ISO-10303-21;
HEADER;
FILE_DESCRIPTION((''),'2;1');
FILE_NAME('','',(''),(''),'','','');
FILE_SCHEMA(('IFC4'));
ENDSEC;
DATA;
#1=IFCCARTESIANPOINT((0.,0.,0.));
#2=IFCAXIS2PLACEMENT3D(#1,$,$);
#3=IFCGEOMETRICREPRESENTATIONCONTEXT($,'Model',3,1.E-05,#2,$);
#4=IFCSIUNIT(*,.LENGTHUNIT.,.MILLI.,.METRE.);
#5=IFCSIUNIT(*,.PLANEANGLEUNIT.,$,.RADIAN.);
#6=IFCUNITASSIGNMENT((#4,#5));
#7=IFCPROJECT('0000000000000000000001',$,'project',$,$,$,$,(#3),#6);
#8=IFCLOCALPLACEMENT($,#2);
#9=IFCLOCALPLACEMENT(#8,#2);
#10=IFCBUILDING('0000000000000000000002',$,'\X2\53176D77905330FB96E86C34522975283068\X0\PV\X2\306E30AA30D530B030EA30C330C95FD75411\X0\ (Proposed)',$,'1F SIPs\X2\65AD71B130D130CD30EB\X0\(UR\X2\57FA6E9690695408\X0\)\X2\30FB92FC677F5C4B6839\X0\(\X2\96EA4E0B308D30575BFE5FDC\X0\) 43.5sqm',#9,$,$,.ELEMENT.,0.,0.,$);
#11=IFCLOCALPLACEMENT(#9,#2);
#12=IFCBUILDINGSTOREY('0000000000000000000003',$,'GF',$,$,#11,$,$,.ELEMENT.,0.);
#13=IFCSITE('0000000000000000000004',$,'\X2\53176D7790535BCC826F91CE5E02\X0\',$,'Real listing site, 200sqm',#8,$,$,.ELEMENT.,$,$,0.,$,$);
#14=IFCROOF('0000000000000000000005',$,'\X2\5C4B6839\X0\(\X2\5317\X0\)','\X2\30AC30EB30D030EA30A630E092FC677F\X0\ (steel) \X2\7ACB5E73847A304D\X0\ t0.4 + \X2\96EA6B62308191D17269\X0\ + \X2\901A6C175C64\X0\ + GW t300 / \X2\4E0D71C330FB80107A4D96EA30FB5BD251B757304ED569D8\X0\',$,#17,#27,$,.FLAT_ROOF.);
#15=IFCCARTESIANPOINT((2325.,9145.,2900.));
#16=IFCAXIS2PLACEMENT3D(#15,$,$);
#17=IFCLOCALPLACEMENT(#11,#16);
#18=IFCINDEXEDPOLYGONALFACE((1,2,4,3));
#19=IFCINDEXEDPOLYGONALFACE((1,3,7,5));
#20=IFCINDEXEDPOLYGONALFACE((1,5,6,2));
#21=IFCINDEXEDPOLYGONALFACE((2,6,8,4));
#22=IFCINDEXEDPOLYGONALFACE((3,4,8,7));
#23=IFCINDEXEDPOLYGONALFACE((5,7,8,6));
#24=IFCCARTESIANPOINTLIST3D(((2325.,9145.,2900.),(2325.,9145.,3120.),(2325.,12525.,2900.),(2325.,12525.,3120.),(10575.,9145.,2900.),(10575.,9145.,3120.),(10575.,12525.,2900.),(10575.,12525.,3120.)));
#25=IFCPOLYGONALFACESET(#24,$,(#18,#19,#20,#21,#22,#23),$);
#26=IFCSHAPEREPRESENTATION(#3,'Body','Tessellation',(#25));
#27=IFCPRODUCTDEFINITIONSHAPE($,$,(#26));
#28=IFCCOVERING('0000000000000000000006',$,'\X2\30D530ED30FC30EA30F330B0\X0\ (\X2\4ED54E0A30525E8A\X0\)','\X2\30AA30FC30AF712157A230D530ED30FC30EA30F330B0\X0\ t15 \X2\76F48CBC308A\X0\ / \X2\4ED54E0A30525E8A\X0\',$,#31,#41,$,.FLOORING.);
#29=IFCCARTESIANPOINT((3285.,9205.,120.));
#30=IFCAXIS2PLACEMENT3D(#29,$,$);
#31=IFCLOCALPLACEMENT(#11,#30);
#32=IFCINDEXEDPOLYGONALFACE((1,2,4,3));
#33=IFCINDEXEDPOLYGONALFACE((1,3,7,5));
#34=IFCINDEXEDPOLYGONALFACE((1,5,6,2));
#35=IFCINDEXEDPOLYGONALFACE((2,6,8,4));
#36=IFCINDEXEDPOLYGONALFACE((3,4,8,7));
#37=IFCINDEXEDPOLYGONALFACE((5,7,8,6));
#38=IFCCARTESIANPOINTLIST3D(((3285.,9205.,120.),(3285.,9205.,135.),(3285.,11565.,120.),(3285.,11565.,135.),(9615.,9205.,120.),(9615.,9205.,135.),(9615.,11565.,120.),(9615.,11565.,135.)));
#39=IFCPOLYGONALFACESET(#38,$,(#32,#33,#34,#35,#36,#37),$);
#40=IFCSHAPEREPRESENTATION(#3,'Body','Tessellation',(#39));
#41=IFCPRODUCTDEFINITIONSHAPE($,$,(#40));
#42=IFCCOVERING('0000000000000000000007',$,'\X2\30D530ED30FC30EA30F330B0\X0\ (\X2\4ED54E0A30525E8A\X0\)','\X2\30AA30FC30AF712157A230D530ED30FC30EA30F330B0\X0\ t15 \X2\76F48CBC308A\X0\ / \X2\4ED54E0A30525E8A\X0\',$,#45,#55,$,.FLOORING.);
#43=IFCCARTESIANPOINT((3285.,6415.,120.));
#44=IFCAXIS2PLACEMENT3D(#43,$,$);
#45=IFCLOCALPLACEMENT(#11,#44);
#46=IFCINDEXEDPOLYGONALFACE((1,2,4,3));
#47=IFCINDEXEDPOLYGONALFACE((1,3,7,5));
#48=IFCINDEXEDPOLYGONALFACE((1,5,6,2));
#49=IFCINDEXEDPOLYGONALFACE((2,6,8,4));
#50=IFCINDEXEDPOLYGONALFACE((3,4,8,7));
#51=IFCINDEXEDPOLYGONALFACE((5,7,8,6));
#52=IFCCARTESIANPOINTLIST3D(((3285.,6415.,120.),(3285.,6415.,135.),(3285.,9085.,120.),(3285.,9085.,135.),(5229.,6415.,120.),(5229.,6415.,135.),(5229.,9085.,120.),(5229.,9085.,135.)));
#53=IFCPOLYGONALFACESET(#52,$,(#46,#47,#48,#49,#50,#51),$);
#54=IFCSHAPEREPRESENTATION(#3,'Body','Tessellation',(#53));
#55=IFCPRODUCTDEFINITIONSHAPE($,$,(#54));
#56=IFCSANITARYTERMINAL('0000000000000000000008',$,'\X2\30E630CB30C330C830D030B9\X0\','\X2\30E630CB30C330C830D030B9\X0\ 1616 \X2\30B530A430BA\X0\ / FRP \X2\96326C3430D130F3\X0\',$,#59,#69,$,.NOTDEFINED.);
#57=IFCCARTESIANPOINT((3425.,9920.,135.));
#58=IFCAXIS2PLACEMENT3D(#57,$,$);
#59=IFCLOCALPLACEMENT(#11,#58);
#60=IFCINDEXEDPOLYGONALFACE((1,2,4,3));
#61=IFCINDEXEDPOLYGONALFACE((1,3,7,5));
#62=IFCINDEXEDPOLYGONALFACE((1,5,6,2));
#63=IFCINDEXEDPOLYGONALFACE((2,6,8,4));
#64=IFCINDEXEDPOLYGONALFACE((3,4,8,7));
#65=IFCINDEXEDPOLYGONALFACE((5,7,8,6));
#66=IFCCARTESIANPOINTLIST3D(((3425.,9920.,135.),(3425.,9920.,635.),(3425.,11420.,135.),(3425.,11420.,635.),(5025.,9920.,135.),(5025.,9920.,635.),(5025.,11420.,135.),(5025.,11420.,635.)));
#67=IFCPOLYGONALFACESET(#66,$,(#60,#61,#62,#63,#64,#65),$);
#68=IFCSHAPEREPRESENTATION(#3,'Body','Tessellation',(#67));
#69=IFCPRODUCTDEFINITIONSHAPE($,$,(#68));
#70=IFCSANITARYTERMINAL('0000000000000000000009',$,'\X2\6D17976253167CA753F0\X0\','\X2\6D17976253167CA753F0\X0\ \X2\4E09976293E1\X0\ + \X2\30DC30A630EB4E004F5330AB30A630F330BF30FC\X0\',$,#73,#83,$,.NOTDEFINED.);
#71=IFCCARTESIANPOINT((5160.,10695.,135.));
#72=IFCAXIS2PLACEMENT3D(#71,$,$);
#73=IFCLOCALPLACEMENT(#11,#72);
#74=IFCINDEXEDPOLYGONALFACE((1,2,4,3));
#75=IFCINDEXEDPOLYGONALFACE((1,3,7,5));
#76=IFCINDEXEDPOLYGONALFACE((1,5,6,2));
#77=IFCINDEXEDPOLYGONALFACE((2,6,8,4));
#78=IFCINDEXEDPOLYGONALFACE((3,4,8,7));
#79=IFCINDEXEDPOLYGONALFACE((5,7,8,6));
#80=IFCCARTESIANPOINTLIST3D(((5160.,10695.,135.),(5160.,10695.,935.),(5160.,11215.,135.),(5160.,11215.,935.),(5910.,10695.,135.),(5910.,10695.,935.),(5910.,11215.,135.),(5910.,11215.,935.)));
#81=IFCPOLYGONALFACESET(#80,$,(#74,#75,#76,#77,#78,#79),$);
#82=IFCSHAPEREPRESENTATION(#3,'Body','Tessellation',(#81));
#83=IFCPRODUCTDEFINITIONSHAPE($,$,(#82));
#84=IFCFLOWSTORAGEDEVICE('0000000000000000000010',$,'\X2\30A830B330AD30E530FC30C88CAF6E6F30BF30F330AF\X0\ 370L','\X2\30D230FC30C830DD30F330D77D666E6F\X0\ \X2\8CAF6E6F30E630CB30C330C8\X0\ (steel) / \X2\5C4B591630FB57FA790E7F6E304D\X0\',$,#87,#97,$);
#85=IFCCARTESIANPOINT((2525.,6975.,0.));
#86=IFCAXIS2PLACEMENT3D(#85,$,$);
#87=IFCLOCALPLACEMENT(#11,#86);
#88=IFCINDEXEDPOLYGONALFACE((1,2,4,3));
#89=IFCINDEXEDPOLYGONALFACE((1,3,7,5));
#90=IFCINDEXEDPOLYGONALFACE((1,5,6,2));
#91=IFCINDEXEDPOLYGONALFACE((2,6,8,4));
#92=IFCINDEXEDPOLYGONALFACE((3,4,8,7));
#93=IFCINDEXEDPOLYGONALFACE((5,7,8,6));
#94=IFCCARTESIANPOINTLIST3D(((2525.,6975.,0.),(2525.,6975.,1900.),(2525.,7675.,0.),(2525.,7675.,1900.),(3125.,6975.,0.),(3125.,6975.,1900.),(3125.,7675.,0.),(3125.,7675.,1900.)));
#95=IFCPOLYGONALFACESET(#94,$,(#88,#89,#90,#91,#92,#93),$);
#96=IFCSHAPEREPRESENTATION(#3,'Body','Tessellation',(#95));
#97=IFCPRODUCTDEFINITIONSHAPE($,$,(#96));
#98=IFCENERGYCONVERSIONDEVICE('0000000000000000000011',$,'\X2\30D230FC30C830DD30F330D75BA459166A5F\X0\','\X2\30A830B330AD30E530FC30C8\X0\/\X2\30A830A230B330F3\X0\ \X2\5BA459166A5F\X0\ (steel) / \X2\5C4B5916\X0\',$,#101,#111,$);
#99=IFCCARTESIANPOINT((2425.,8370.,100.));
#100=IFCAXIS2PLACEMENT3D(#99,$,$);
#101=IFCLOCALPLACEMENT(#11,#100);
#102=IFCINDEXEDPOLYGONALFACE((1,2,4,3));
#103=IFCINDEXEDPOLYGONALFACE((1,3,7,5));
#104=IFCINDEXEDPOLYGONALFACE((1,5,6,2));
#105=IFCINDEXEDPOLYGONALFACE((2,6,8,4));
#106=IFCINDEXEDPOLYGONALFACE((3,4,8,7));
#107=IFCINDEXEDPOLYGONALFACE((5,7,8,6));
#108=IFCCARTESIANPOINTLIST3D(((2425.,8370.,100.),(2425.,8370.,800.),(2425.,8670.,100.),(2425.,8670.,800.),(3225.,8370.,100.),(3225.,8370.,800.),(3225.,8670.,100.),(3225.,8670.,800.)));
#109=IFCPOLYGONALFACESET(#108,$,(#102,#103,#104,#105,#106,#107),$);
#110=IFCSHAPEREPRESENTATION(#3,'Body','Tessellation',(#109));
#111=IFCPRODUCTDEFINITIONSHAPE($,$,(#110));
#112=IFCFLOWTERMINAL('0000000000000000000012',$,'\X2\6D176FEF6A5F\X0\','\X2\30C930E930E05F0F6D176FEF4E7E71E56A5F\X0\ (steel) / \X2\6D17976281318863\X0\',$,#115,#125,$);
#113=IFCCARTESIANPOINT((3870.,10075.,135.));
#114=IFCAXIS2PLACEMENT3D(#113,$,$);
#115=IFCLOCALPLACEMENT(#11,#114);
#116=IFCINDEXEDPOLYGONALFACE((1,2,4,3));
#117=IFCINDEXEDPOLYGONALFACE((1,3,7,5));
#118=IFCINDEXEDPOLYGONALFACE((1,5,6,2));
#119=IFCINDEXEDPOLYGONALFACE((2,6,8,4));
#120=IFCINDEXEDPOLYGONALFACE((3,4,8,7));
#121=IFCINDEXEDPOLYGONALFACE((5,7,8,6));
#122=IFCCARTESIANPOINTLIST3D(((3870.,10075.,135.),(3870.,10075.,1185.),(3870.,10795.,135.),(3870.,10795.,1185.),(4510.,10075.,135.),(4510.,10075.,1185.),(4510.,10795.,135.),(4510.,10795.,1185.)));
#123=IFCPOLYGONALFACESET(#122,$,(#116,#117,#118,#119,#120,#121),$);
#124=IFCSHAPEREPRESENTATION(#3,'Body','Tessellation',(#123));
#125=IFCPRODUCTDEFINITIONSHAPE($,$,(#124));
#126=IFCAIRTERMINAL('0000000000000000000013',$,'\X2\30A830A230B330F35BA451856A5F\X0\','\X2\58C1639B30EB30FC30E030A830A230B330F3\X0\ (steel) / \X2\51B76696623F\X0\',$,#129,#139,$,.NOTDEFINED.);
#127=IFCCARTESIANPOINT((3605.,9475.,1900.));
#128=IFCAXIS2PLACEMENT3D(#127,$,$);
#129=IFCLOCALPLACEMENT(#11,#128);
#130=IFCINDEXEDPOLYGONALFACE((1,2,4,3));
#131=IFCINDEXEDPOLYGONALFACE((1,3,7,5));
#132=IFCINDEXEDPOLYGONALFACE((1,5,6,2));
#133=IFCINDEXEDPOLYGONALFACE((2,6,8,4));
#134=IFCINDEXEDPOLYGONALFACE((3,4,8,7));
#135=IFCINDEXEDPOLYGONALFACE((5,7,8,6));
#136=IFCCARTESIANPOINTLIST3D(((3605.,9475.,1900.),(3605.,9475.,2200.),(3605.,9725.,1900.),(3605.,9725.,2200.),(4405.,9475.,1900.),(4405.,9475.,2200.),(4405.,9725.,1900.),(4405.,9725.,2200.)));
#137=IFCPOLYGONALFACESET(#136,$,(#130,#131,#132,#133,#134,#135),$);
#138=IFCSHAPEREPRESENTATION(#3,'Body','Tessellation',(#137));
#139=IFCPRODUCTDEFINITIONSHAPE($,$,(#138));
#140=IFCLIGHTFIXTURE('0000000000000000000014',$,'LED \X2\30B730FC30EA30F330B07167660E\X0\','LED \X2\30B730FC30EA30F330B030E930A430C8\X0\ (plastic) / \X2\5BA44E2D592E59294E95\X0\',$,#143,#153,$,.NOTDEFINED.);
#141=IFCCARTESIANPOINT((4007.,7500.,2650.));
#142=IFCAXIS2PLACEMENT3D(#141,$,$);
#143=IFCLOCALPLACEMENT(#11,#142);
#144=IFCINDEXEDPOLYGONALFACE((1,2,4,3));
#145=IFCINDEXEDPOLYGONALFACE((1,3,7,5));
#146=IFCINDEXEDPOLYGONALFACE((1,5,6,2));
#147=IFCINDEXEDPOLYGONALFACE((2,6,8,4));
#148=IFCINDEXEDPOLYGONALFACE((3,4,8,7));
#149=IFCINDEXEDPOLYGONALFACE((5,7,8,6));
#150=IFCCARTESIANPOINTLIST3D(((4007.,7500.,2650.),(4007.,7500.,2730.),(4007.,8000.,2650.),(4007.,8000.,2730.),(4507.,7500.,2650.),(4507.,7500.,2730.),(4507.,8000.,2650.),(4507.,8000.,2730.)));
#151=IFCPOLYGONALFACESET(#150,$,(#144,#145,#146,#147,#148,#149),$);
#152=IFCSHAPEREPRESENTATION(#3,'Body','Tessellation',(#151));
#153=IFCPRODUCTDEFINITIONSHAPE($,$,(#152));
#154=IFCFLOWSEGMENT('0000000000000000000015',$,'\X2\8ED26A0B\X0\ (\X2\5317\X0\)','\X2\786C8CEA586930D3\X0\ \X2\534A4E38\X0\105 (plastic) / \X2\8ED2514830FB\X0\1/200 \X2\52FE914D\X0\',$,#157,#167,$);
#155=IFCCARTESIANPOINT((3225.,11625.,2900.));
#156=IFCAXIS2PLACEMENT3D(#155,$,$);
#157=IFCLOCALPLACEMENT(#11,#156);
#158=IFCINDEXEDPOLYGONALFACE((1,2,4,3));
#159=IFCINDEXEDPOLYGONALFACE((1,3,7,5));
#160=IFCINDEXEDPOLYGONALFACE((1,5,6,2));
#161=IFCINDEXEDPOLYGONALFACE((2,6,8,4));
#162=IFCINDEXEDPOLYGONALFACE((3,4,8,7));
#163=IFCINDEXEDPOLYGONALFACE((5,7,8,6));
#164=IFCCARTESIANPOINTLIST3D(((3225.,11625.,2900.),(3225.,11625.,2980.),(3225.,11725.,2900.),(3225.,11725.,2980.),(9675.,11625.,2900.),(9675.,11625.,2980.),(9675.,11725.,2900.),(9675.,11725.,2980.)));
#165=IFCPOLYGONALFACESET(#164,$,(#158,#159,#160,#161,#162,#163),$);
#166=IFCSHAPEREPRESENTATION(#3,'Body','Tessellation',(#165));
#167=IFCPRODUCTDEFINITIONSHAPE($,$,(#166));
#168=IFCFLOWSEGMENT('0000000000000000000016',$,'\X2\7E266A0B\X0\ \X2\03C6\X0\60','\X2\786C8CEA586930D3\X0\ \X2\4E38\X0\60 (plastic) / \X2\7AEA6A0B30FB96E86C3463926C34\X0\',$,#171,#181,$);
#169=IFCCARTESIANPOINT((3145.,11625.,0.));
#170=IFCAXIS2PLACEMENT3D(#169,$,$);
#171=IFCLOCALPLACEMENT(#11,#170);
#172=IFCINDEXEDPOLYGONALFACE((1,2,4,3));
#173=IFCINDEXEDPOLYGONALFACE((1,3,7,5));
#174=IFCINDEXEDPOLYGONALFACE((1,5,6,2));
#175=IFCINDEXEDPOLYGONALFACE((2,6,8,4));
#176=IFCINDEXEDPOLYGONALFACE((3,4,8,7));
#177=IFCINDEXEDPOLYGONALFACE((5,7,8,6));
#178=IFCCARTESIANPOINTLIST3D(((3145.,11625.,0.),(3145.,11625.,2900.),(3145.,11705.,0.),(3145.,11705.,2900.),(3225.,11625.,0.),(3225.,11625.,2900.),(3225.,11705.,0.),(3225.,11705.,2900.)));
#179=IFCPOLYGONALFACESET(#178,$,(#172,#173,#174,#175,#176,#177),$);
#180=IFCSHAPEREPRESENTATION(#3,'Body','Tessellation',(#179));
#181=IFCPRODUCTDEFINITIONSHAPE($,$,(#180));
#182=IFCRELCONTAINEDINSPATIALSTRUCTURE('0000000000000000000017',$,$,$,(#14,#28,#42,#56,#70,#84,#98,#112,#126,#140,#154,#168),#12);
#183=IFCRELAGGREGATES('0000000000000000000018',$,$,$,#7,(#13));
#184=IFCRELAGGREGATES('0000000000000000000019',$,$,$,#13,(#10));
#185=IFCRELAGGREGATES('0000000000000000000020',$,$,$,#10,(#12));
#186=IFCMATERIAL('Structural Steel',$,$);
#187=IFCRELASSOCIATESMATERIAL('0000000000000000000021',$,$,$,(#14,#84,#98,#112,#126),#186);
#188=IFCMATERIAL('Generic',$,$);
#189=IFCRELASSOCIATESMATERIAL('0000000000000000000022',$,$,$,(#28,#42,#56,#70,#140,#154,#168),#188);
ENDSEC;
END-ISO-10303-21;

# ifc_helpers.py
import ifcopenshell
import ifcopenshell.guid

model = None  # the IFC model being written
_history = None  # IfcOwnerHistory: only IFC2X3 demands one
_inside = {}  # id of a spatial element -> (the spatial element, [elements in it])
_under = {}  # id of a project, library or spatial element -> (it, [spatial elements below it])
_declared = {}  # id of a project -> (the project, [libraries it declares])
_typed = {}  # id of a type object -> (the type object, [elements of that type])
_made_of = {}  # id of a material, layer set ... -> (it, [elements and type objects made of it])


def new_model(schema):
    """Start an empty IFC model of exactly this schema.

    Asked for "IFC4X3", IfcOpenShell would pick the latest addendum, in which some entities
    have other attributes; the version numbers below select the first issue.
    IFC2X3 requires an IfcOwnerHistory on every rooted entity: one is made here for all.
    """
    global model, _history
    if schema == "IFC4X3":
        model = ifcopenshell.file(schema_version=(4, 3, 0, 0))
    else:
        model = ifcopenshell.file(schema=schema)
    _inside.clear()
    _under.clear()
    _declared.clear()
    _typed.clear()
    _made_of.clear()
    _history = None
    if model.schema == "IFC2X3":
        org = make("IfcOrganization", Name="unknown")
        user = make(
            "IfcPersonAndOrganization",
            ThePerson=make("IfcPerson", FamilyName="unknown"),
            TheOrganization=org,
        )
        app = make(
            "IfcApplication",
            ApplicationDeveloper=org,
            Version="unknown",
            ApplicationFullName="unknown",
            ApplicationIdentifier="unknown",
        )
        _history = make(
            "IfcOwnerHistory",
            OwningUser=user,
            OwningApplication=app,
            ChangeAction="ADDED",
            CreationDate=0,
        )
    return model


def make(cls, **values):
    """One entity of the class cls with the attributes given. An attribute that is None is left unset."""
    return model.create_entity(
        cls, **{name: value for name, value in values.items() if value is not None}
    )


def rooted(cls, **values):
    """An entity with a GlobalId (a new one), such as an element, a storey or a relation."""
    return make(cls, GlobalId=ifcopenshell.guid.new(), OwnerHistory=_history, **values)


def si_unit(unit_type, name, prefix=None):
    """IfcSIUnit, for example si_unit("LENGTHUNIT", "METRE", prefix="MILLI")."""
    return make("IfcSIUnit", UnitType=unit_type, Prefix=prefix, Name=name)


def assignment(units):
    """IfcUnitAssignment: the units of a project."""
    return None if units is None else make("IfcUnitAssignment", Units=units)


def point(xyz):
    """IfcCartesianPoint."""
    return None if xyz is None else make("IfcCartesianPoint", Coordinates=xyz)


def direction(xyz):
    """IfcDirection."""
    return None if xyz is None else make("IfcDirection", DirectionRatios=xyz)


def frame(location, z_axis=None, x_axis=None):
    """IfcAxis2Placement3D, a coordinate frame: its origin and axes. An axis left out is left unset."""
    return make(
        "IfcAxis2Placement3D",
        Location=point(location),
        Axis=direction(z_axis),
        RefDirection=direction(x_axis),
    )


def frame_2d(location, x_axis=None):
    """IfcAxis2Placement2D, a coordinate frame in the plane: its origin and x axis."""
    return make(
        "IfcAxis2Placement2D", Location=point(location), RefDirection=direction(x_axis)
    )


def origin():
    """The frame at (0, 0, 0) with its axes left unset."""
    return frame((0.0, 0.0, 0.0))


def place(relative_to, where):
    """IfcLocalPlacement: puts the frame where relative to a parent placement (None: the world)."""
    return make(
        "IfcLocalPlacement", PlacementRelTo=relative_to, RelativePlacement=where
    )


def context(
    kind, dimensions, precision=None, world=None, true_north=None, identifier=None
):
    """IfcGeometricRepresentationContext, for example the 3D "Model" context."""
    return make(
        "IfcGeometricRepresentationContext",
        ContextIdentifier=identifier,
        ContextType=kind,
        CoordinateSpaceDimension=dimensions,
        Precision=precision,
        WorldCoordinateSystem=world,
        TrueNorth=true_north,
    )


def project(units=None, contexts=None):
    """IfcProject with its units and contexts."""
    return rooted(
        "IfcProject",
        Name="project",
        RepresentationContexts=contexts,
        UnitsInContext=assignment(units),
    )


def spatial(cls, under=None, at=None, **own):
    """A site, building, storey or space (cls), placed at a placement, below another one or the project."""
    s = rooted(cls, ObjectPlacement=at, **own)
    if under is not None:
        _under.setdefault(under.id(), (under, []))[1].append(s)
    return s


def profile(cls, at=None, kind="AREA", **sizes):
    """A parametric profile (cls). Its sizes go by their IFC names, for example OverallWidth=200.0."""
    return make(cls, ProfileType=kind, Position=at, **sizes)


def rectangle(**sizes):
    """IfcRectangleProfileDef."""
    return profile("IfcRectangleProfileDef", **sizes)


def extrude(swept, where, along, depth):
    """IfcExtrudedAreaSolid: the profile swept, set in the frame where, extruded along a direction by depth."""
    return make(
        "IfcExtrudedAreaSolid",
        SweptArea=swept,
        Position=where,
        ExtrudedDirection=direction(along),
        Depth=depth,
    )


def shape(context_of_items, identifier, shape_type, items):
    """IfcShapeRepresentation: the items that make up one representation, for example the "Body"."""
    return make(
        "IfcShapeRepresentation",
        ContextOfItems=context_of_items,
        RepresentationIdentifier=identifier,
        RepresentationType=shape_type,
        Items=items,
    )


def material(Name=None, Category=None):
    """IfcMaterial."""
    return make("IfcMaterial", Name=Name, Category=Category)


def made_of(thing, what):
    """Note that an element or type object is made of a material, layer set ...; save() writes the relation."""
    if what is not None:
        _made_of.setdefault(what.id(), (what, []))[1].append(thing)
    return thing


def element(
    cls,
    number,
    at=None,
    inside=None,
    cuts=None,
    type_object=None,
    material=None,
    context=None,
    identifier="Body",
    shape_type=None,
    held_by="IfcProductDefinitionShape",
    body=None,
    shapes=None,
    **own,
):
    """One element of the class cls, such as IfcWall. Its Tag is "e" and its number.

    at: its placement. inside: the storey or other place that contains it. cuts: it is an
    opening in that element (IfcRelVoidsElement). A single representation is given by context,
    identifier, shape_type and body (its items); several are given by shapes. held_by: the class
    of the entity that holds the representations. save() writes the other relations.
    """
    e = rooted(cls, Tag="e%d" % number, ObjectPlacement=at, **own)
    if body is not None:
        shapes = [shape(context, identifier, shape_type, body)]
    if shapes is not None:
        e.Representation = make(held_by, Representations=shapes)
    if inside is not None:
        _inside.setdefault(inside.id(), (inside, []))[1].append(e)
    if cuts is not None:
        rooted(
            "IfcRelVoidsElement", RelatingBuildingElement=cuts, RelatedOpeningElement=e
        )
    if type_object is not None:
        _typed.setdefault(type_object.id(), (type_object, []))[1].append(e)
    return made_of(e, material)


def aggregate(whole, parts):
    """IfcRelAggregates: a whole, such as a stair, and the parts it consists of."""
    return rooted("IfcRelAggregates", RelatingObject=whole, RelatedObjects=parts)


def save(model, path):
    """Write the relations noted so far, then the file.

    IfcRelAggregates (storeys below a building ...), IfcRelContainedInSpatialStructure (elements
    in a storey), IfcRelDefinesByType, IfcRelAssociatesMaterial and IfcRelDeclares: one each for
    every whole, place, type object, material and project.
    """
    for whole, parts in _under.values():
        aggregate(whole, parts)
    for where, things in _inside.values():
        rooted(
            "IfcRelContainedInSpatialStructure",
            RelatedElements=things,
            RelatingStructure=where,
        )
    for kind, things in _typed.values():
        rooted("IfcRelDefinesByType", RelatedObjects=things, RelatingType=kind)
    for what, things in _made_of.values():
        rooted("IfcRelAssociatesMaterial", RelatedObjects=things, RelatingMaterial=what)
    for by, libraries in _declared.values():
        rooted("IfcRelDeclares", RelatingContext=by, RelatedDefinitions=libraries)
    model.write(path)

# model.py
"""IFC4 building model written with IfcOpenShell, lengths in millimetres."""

from ifc_helpers import new_model, si_unit, frame, frame_2d, origin, place, context, project, spatial, rectangle, extrude, material, element, save


model = new_model("IFC4")

# Units and contexts
model_context = context("Model", 3, precision=1e-05, world=origin())
ifc_project = project(units=[si_unit("LENGTHUNIT", "METRE", prefix="MILLI"), si_unit("PLANEANGLEUNIT", "RADIAN")], contexts=[model_context])

# Site, building, storey
site_placement = place(None, origin())
site = spatial("IfcSite", under=ifc_project, at=site_placement, Name="北海道富良野市", ObjectType="Real listing site, 200sqm", CompositionType="ELEMENT", RefElevation=0.0)
building_placement = place(site_placement, origin())
building = spatial("IfcBuilding", under=site, at=building_placement, Name="北海道・雨水利用とPVのオフグリッド志向 (Proposed)", ObjectType="1F SIPs断熱パネル(UR基準適合)・鋼板屋根(雪下ろし対応) 43.5sqm", CompositionType="ELEMENT", ElevationOfRefHeight=0.0, ElevationOfTerrain=0.0)
storey_placement = place(building_placement, origin())
storey = spatial("IfcBuildingStorey", under=building, at=storey_placement, Name="GF", CompositionType="ELEMENT", Elevation=0.0)

# Roof
ifc_material_1 = material(Name="Structural Steel")
roof_placement = place(storey_placement, frame((2325.0, 9145.0, 2900.0)))
element("IfcRoof", 1, at=roof_placement, inside=storey, material=ifc_material_1, Name="屋根(北)", Description="ガルバリウム鋼板 (steel) 立平葺き t0.4 + 雪止め金物 + 通気層 + GW t300 / 不燃・耐積雪・寒冷地仕様", PredefinedType="FLAT_ROOF", context=model_context, shape_type="SweptSolid", body=[
    extrude(rectangle(XDim=8250.0, YDim=3380.0, at=frame_2d((4125.0, 1690.0))), frame((2325.0, 9145.0, 2900.0)), (0.0, 0.0, 1.0), 220.0),
])

# Coverings
ifc_material_2 = material(Name="Generic")
covering_1_placement = place(storey_placement, frame((3285.0, 9205.0, 120.0)))
element("IfcCovering", 2, at=covering_1_placement, inside=storey, material=ifc_material_2, Name="フローリング (仕上げ床)", Description="オーク無垢フローリング t15 直貼り / 仕上げ床", PredefinedType="FLOORING", context=model_context, shape_type="SweptSolid", body=[
    extrude(rectangle(XDim=6330.0, YDim=2360.0, at=frame_2d((3165.0, 1180.0))), frame((3285.0, 9205.0, 120.0)), (0.0, 0.0, 1.0), 15.0),
])
covering_2_placement = place(storey_placement, frame((3285.0, 6415.0, 120.0)))
element("IfcCovering", 3, at=covering_2_placement, inside=storey, material=ifc_material_2, Name="フローリング (仕上げ床)", Description="オーク無垢フローリング t15 直貼り / 仕上げ床", PredefinedType="FLOORING", context=model_context, shape_type="SweptSolid", body=[
    extrude(rectangle(XDim=1944.0, YDim=2670.0, at=frame_2d((972.0, 1335.0))), frame((3285.0, 6415.0, 120.0)), (0.0, 0.0, 1.0), 15.0),
])

# Sanitary terminals
sanitary_terminal_1_placement = place(storey_placement, frame((3425.0, 9920.0, 135.0)))
element("IfcSanitaryTerminal", 4, at=sanitary_terminal_1_placement, inside=storey, material=ifc_material_2, Name="ユニットバス", Description="ユニットバス 1616 サイズ / FRP 防水パン", PredefinedType="NOTDEFINED", context=model_context, shape_type="SweptSolid", body=[
    extrude(rectangle(XDim=1600.0, YDim=1500.0, at=frame_2d((800.0, 750.0))), frame((3425.0, 9920.0, 135.0)), (0.0, 0.0, 1.0), 500.0),
])
sanitary_terminal_2_placement = place(storey_placement, frame((5160.0, 10695.0, 135.0)))
element("IfcSanitaryTerminal", 5, at=sanitary_terminal_2_placement, inside=storey, material=ifc_material_2, Name="洗面化粧台", Description="洗面化粧台 三面鏡 + ボウル一体カウンター", PredefinedType="NOTDEFINED", context=model_context, shape_type="SweptSolid", body=[
    extrude(rectangle(XDim=750.0, YDim=520.0, at=frame_2d((375.0, 260.0))), frame((5160.0, 10695.0, 135.0)), (0.0, 0.0, 1.0), 800.0),
])

# Flow storage device
flow_storage_device_placement = place(storey_placement, frame((2525.0, 6975.0, 0.0)))
element("IfcFlowStorageDevice", 6, at=flow_storage_device_placement, inside=storey, material=ifc_material_1, Name="エコキュート貯湯タンク 370L", Description="ヒートポンプ給湯 貯湯ユニット (steel) / 屋外・基礎置き", context=model_context, shape_type="SweptSolid", body=[
    extrude(rectangle(XDim=600.0, YDim=700.0, at=frame_2d((300.0, 350.0))), frame((2525.0, 6975.0, 0.0)), (0.0, 0.0, 1.0), 1900.0),
])

# Energy conversion device
energy_conversion_device_placement = place(storey_placement, frame((2425.0, 8370.0, 100.0)))
element("IfcEnergyConversionDevice", 7, at=energy_conversion_device_placement, inside=storey, material=ifc_material_1, Name="ヒートポンプ室外機", Description="エコキュート/エアコン 室外機 (steel) / 屋外", context=model_context, shape_type="SweptSolid", body=[
    extrude(rectangle(XDim=800.0, YDim=300.0, at=frame_2d((400.0, 150.0))), frame((2425.0, 8370.0, 100.0)), (0.0, 0.0, 1.0), 700.0),
])

# Flow terminal
flow_terminal_placement = place(storey_placement, frame((3870.0, 10075.0, 135.0)))
element("IfcFlowTerminal", 8, at=flow_terminal_placement, inside=storey, material=ifc_material_1, Name="洗濯機", Description="ドラム式洗濯乾燥機 (steel) / 洗面脱衣", context=model_context, shape_type="SweptSolid", body=[
    extrude(rectangle(XDim=640.0, YDim=720.0, at=frame_2d((320.0, 360.0))), frame((3870.0, 10075.0, 135.0)), (0.0, 0.0, 1.0), 1050.0),
])

# Air terminal
air_terminal_placement = place(storey_placement, frame((3605.0, 9475.0, 1900.0)))
element("IfcAirTerminal", 9, at=air_terminal_placement, inside=storey, material=ifc_material_1, Name="エアコン室内機", Description="壁掛ルームエアコン (steel) / 冷暖房", PredefinedType="NOTDEFINED", context=model_context, shape_type="SweptSolid", body=[
    extrude(rectangle(XDim=800.0, YDim=250.0, at=frame_2d((400.0, 125.0))), frame((3605.0, 9475.0, 1900.0)), (0.0, 0.0, 1.0), 300.0),
])

# Light fixture
light_fixture_placement = place(storey_placement, frame((4007.0, 7500.0, 2650.0)))
element("IfcLightFixture", 10, at=light_fixture_placement, inside=storey, material=ifc_material_2, Name="LED シーリング照明", Description="LED シーリングライト (plastic) / 室中央天井", PredefinedType="NOTDEFINED", context=model_context, shape_type="SweptSolid", body=[
    extrude(rectangle(XDim=500.0, YDim=500.0, at=frame_2d((250.0, 250.0))), frame((4007.0, 7500.0, 2650.0)), (0.0, 0.0, 1.0), 80.0),
])

# Flow segments
flow_segment_1_placement = place(storey_placement, frame((3225.0, 11625.0, 2900.0)))
element("IfcFlowSegment", 11, at=flow_segment_1_placement, inside=storey, material=ifc_material_2, Name="軒樋 (北)", Description="硬質塩ビ 半丸105 (plastic) / 軒先・1/200 勾配", context=model_context, shape_type="SweptSolid", body=[
    extrude(rectangle(XDim=6450.0, YDim=100.0, at=frame_2d((3225.0, 50.0))), frame((3225.0, 11625.0, 2900.0)), (0.0, 0.0, 1.0), 80.0),
])
flow_segment_2_placement = place(storey_placement, frame((3145.0, 11625.0, 0.0)))
element("IfcFlowSegment", 12, at=flow_segment_2_placement, inside=storey, material=ifc_material_2, Name="縦樋 φ60", Description="硬質塩ビ 丸60 (plastic) / 竪樋・雨水排水", context=model_context, shape_type="SweptSolid", body=[
    extrude(rectangle(XDim=80.0, YDim=80.0, at=frame_2d((40.0, 40.0))), frame((3145.0, 11625.0, 0.0)), (0.0, 0.0, 1.0), 2900.0),
])

save(model, "model.ifc")
